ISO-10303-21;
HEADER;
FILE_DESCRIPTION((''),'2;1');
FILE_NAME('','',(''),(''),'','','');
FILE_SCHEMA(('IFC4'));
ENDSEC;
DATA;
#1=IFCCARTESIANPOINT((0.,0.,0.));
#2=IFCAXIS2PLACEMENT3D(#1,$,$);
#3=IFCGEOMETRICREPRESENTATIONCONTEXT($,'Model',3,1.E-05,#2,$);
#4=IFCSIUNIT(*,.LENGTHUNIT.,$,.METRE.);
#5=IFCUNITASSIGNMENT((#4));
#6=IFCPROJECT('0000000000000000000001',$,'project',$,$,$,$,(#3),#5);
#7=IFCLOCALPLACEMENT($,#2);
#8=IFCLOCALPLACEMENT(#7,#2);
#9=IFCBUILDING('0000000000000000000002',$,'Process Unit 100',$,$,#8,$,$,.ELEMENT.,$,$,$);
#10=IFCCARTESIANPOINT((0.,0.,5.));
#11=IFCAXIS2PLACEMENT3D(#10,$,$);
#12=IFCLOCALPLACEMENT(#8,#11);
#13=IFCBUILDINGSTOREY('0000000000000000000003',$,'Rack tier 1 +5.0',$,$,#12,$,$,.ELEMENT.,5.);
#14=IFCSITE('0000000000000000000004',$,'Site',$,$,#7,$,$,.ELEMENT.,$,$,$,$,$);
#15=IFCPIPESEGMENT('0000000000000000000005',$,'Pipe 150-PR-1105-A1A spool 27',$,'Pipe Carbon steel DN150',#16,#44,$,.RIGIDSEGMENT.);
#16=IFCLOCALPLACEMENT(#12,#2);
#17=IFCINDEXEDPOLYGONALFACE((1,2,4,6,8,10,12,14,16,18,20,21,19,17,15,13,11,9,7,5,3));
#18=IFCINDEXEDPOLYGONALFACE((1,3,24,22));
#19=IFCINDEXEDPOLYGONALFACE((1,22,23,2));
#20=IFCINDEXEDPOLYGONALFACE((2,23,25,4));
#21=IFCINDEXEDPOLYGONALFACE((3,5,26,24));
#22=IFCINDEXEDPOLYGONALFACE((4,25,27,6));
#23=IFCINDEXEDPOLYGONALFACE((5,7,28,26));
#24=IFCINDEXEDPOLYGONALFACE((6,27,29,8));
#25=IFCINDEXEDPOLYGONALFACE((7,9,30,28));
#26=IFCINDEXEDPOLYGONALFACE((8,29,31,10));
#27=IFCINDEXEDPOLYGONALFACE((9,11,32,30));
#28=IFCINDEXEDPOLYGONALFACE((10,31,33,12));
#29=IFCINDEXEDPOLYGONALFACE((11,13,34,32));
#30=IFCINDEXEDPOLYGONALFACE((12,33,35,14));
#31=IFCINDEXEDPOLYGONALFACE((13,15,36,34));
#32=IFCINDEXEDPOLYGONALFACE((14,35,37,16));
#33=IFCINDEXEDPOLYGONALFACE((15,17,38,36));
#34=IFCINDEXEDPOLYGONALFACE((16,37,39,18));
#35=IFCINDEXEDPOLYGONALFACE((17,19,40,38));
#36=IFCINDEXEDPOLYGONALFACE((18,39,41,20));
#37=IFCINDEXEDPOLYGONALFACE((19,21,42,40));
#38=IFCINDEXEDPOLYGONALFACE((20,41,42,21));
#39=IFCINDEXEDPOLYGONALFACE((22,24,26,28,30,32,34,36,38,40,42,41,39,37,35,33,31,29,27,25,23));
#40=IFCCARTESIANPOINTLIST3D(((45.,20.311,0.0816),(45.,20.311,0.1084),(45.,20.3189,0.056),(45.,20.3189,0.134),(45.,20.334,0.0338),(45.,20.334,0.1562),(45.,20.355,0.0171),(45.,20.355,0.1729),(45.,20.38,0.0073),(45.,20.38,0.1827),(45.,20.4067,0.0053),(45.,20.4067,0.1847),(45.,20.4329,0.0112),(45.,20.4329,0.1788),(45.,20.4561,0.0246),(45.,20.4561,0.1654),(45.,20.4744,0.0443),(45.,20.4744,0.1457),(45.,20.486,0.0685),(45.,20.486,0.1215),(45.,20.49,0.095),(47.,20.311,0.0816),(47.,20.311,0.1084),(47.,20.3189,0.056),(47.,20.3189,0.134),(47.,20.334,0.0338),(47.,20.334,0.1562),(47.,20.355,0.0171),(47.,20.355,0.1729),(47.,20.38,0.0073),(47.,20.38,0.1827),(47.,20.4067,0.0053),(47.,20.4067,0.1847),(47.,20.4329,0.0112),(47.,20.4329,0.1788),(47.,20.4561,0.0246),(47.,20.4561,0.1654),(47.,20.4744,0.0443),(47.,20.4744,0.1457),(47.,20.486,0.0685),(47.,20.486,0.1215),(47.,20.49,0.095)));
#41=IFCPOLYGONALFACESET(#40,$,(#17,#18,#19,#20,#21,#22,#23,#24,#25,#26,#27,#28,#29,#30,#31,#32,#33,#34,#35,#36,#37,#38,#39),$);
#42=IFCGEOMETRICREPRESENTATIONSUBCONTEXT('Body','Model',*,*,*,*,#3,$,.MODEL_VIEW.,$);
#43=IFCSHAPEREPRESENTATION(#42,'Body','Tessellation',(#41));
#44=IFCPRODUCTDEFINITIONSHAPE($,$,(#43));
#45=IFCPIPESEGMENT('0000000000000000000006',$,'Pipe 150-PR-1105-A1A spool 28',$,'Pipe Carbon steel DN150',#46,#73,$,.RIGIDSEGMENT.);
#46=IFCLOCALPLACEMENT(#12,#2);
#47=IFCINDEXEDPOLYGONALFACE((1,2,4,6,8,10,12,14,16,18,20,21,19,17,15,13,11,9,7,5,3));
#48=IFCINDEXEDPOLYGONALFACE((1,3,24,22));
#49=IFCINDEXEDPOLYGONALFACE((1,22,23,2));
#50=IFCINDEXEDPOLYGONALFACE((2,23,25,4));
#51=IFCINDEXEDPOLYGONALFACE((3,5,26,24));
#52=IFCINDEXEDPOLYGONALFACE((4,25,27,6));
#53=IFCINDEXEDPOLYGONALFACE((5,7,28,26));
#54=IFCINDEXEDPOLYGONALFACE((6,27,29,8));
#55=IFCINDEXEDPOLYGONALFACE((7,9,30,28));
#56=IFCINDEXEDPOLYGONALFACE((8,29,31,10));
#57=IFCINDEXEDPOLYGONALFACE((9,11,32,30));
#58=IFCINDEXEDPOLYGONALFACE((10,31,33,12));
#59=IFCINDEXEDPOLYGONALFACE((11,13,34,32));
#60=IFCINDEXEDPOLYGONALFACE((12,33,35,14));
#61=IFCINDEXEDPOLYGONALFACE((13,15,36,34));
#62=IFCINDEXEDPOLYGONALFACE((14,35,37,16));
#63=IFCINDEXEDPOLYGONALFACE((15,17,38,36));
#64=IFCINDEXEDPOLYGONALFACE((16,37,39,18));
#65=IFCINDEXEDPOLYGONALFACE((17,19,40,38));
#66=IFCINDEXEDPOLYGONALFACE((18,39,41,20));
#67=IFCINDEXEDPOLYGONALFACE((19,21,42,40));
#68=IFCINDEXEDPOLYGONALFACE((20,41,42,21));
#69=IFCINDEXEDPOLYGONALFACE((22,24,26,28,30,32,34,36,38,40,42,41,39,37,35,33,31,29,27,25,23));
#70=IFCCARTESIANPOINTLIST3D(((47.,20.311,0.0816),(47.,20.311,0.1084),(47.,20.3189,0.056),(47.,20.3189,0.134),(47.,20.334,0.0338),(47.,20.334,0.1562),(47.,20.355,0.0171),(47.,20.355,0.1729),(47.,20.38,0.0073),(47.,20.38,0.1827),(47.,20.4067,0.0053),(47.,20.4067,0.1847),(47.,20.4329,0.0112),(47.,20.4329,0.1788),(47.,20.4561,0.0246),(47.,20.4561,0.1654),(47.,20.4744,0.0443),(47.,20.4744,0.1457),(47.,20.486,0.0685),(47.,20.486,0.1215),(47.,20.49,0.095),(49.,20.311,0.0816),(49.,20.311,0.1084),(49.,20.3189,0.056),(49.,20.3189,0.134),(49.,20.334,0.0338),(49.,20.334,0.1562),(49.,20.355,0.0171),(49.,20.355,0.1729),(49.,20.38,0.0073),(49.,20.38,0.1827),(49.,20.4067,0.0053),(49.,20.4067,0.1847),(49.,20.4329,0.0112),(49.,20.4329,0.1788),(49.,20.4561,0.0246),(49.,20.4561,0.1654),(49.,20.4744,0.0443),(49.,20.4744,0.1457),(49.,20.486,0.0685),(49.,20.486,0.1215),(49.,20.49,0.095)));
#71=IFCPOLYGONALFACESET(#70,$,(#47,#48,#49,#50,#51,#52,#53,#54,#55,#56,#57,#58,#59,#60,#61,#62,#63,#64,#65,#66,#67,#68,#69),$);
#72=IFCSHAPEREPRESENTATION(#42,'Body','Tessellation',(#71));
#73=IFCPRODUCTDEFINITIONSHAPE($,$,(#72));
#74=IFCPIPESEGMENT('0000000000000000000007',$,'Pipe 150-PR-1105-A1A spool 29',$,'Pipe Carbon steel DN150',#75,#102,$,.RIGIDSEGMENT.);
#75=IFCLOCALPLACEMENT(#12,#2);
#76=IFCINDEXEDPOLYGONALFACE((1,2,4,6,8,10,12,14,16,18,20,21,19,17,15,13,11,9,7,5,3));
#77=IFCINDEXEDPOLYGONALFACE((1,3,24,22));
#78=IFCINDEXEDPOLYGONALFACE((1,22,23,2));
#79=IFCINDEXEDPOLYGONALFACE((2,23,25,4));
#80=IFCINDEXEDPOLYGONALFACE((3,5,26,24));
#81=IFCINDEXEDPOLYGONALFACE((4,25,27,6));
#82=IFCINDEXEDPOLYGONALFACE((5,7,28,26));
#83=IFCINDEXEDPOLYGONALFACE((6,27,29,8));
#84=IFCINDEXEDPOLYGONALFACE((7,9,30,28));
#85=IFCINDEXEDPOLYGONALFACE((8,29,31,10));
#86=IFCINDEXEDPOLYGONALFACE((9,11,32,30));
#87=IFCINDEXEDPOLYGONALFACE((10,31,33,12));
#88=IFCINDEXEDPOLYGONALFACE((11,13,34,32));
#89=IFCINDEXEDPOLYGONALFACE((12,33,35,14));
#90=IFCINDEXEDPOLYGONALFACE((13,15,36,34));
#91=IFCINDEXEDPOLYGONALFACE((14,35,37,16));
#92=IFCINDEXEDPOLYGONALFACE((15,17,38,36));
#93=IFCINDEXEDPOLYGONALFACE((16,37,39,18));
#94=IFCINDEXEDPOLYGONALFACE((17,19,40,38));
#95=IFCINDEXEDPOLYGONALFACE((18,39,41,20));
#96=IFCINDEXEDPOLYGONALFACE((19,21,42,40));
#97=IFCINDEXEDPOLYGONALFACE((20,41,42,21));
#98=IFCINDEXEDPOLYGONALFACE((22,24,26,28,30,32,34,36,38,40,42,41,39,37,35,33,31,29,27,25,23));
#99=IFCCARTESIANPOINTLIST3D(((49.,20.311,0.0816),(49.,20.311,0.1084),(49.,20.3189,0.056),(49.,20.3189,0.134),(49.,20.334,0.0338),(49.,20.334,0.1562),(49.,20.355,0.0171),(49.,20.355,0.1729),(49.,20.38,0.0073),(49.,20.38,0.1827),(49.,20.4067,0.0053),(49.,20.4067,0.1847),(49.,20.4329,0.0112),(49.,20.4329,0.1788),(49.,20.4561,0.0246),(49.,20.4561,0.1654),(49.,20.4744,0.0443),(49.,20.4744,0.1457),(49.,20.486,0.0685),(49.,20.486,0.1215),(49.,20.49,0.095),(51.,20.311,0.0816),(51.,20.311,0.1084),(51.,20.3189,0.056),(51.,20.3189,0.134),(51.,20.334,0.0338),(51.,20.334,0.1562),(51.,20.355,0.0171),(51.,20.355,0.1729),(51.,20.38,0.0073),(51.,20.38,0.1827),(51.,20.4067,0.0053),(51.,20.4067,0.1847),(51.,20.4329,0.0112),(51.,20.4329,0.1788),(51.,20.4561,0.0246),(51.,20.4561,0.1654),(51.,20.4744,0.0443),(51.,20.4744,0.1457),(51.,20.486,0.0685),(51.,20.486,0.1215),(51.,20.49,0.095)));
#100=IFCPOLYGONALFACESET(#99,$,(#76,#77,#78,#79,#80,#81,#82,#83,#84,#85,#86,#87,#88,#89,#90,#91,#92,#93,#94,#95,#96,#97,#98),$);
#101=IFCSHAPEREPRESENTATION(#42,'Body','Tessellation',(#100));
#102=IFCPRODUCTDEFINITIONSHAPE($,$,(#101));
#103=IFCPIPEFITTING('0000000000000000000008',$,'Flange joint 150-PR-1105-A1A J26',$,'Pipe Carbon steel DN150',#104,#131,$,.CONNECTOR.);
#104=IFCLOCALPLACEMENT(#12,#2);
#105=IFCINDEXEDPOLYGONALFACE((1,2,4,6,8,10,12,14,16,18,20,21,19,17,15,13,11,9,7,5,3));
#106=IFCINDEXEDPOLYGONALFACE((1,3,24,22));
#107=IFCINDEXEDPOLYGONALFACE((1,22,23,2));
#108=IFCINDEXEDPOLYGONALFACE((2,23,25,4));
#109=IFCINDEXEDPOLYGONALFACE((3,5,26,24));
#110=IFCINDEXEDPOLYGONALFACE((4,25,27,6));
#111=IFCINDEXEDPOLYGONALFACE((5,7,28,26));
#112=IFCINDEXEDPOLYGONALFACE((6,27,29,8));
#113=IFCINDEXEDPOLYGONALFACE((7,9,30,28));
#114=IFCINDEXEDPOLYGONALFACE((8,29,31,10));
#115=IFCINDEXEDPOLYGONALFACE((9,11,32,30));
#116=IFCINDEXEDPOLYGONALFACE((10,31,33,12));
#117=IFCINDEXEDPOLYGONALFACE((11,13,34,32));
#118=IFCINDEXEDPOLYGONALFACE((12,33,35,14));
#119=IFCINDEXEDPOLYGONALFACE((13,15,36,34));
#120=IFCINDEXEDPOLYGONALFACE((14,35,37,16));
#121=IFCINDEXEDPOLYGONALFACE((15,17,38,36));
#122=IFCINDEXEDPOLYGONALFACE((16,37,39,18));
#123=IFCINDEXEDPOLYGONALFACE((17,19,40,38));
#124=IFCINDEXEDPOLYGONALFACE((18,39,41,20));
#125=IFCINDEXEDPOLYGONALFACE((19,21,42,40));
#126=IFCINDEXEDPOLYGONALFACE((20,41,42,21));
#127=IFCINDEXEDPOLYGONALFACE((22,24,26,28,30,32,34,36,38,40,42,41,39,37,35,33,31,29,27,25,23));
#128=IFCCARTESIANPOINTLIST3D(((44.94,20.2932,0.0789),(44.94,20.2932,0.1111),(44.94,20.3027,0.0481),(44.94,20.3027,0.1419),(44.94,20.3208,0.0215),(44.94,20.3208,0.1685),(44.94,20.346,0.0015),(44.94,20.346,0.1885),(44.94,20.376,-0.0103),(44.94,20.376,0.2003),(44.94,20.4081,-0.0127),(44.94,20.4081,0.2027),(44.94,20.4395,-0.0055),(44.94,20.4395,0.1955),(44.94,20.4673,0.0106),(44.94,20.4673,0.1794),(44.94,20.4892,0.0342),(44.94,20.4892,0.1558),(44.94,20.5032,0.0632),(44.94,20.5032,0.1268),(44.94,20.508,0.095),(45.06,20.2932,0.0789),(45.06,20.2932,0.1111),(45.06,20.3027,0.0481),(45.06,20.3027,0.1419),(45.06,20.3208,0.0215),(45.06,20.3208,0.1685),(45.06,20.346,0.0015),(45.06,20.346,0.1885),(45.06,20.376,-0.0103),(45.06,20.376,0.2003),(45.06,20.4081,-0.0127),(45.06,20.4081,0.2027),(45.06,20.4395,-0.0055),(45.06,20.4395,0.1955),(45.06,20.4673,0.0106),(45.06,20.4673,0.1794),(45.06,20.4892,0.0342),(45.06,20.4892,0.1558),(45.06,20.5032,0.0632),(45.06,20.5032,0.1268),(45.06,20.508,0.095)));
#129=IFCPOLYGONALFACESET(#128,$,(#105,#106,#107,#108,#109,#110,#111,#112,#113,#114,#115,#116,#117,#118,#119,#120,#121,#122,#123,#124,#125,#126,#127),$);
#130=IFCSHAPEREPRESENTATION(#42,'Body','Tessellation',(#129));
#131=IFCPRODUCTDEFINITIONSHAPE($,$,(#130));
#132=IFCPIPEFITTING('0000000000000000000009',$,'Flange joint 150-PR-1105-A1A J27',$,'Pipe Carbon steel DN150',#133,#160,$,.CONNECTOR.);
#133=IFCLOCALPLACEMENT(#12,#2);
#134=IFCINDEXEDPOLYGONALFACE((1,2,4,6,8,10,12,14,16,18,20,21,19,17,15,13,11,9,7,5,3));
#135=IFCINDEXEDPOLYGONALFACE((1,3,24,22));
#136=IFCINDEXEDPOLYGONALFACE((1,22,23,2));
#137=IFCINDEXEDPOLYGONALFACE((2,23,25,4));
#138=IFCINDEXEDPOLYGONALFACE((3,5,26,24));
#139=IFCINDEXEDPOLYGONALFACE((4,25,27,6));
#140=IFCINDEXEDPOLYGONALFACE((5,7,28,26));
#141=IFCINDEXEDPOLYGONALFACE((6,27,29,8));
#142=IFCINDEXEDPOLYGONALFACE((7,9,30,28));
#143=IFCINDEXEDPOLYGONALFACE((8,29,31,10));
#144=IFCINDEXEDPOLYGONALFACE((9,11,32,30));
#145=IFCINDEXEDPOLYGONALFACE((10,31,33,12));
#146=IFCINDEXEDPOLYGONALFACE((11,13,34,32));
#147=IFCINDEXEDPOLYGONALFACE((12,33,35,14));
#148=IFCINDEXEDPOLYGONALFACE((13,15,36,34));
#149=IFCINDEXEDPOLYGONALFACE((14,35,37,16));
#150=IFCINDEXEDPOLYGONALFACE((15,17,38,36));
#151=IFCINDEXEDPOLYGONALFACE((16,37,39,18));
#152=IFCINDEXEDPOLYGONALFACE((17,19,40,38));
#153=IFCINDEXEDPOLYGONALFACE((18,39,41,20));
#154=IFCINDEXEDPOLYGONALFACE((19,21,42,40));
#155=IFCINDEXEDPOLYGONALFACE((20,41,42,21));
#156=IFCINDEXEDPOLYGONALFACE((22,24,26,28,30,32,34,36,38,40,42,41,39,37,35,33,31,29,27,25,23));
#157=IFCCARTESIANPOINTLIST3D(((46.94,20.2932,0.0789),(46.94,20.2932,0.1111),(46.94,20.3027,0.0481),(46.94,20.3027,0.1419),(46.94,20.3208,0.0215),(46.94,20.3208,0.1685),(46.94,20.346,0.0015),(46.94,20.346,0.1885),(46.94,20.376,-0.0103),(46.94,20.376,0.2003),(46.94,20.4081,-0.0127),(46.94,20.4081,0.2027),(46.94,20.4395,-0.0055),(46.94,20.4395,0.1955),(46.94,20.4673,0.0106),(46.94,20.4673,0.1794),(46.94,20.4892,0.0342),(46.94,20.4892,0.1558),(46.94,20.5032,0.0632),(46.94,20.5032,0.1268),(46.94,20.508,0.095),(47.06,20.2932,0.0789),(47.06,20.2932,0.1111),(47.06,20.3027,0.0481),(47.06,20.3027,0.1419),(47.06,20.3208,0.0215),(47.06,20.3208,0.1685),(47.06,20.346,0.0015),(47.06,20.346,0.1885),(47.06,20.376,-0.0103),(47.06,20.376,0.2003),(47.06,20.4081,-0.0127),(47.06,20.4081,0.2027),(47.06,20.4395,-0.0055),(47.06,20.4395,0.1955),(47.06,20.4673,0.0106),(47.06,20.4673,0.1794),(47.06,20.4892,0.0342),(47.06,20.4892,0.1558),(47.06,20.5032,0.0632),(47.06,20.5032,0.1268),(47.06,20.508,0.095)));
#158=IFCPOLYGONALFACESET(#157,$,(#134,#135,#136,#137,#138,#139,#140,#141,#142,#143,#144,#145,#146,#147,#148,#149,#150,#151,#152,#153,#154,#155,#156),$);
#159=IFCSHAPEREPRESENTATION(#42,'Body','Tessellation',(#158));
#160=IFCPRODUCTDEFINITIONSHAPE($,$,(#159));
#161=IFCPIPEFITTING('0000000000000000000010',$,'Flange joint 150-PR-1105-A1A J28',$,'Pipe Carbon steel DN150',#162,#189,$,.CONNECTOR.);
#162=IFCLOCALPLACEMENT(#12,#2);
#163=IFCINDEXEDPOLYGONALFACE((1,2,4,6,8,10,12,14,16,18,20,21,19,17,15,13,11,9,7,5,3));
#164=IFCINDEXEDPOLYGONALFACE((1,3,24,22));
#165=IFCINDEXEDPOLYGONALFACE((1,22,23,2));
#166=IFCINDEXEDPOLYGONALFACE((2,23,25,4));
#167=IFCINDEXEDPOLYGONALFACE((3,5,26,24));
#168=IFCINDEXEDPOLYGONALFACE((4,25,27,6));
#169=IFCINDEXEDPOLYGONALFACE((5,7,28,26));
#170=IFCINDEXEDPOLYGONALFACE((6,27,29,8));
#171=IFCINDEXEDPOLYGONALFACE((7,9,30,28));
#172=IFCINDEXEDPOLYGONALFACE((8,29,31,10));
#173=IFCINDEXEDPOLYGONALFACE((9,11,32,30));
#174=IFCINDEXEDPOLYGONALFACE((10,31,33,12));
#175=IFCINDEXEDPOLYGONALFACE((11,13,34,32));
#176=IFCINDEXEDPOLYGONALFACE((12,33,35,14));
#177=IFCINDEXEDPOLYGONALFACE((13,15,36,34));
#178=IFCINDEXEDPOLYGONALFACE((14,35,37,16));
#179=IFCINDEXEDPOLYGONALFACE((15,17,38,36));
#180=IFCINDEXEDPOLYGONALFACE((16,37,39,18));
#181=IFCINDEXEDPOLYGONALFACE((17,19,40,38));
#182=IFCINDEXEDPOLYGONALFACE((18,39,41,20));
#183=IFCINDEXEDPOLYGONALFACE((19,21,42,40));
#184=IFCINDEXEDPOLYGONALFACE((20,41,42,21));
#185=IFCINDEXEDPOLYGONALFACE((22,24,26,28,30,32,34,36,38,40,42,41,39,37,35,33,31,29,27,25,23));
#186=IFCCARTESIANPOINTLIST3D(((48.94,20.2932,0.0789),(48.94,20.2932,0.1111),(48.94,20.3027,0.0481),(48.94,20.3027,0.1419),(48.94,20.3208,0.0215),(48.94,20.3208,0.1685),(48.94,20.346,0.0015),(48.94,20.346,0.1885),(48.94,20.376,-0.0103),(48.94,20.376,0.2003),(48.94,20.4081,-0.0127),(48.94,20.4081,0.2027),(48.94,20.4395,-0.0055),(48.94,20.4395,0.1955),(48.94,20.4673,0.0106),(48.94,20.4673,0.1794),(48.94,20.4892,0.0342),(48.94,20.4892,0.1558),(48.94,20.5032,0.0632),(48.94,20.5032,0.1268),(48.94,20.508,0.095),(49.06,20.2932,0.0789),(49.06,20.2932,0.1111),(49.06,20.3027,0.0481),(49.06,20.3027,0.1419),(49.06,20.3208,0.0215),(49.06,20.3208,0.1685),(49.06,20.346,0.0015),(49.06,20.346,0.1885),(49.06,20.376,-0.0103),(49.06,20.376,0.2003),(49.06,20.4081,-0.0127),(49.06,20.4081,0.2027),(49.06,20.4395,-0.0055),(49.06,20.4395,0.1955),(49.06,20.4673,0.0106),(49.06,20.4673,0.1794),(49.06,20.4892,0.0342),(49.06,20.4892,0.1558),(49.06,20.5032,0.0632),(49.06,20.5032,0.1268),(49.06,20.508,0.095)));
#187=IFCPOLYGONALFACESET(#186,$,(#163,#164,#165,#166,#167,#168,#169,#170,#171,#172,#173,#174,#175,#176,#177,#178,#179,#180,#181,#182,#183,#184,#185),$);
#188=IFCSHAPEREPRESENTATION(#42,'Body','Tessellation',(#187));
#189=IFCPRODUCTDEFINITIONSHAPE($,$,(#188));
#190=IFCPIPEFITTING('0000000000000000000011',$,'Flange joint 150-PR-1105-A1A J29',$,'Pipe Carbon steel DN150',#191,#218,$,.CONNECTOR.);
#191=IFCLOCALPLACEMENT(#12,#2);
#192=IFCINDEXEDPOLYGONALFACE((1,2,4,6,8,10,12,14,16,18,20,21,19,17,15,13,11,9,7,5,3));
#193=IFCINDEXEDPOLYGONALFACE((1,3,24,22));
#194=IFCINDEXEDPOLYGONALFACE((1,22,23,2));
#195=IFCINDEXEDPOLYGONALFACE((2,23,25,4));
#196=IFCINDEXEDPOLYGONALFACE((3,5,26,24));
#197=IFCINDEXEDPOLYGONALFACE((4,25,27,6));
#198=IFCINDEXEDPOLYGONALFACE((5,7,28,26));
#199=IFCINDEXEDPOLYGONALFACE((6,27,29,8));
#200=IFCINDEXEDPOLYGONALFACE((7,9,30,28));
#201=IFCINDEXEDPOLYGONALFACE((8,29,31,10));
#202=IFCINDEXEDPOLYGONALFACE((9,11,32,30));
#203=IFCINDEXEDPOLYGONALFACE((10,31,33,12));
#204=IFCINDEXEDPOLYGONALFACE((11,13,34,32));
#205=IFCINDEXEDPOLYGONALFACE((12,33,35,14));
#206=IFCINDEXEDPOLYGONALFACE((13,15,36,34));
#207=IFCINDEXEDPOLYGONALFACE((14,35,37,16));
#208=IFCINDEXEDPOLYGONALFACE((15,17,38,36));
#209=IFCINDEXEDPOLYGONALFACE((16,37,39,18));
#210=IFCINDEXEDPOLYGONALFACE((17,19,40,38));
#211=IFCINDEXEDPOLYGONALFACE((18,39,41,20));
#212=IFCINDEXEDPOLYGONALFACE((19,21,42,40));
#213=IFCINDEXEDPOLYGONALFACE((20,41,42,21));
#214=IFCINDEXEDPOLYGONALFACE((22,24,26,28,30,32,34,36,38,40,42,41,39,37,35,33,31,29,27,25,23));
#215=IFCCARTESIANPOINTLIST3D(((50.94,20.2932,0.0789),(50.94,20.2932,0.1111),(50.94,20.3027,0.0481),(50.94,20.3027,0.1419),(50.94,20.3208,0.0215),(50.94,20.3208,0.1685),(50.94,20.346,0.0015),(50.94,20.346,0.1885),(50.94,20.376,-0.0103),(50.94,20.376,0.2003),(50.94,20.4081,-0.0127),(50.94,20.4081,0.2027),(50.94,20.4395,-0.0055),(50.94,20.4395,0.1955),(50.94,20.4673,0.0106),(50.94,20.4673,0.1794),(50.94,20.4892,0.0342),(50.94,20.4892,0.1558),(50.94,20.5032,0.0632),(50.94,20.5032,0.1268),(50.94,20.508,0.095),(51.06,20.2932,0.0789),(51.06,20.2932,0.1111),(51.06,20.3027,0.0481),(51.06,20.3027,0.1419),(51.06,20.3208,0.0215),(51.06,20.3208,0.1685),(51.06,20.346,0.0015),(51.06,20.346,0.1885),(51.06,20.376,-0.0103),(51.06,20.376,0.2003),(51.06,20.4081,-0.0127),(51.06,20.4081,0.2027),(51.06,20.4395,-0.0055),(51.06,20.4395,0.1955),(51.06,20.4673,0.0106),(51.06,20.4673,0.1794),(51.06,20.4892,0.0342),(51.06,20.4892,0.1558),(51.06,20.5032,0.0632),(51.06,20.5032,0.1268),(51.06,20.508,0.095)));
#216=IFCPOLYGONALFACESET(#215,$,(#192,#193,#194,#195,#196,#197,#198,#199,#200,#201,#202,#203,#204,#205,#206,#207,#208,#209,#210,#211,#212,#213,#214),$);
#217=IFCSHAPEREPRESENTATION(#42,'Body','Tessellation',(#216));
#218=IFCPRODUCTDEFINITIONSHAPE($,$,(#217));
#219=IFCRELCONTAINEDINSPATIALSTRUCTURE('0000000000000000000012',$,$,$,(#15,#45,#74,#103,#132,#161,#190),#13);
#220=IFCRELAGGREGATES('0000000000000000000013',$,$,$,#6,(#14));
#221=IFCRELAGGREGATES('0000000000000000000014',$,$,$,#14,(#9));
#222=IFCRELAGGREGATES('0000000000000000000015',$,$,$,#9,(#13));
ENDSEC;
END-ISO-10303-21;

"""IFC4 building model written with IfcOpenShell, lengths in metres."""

from ifc_helpers import new_model, si_unit, frame, origin, place, context, subcontext, project, spatial, circle, extrude, element, save


model = new_model("IFC4")

# Units and contexts
model_context = context("Model", 3, precision=1e-05, world=origin())
body_context = subcontext(model_context, "Body", "Model", "MODEL_VIEW")
ifc_project = project(units=[si_unit("LENGTHUNIT", "METRE")], contexts=[model_context])

# Site, building, storey
site_placement = place(None, origin())
site = spatial("IfcSite", under=ifc_project, at=site_placement, Name="Site", CompositionType="ELEMENT")
building_placement = place(site_placement, origin())
building = spatial("IfcBuilding", under=site, at=building_placement, Name="Process Unit 100", CompositionType="ELEMENT")
storey_placement = place(building_placement, frame((0.0, 0.0, 5.0)))
storey = spatial("IfcBuildingStorey", under=building, at=storey_placement, Name="Rack tier 1 +5.0", CompositionType="ELEMENT", Elevation=5.0)

# Pipe segments
for number, where, z_axis, x_axis, name in (
    (1, (45.0, 20.4, 0.095), (1.0, 0.0, 0.0), (0.0, 1.0, 0.0), "Pipe 150-PR-1105-A1A spool 27"),
    (2, (47.0, 20.4, 0.095), (1.0, 0.0, 0.0), (0.0, 1.0, 0.0), "Pipe 150-PR-1105-A1A spool 28"),
    (3, (49.0, 20.4, 0.095), (1.0, 0.0, 0.0), (0.0, 1.0, 0.0), "Pipe 150-PR-1105-A1A spool 29"),
):
    element("IfcPipeSegment", number, at=place(storey_placement, frame(where, z_axis=z_axis, x_axis=x_axis)), inside=storey, Name=name, ObjectType="Pipe Carbon steel DN150", PredefinedType="RIGIDSEGMENT", context=body_context, shape_type="SweptSolid", body=[
        extrude(circle(Radius=0.09), origin(), (0.0, 0.0, 1.0), 2.0),
    ])

# Pipe fittings
for number, where, z_axis, x_axis, name in (
    (4, (44.94, 20.4, 0.095), (1.0, 0.0, 0.0), (0.0, 1.0, 0.0), "Flange joint 150-PR-1105-A1A J26"),
    (5, (46.94, 20.4, 0.095), (1.0, 0.0, 0.0), (0.0, 1.0, 0.0), "Flange joint 150-PR-1105-A1A J27"),
    (6, (48.94, 20.4, 0.095), (1.0, 0.0, 0.0), (0.0, 1.0, 0.0), "Flange joint 150-PR-1105-A1A J28"),
    (7, (50.94, 20.4, 0.095), (1.0, 0.0, 0.0), (0.0, 1.0, 0.0), "Flange joint 150-PR-1105-A1A J29"),
):
    element("IfcPipeFitting", number, at=place(storey_placement, frame(where, z_axis=z_axis, x_axis=x_axis)), inside=storey, Name=name, ObjectType="Pipe Carbon steel DN150", PredefinedType="CONNECTOR", context=body_context, shape_type="SweptSolid", body=[
        extrude(circle(Radius=0.108), origin(), (0.0, 0.0, 1.0), 0.12),
    ])

save(model, "model.ifc")
